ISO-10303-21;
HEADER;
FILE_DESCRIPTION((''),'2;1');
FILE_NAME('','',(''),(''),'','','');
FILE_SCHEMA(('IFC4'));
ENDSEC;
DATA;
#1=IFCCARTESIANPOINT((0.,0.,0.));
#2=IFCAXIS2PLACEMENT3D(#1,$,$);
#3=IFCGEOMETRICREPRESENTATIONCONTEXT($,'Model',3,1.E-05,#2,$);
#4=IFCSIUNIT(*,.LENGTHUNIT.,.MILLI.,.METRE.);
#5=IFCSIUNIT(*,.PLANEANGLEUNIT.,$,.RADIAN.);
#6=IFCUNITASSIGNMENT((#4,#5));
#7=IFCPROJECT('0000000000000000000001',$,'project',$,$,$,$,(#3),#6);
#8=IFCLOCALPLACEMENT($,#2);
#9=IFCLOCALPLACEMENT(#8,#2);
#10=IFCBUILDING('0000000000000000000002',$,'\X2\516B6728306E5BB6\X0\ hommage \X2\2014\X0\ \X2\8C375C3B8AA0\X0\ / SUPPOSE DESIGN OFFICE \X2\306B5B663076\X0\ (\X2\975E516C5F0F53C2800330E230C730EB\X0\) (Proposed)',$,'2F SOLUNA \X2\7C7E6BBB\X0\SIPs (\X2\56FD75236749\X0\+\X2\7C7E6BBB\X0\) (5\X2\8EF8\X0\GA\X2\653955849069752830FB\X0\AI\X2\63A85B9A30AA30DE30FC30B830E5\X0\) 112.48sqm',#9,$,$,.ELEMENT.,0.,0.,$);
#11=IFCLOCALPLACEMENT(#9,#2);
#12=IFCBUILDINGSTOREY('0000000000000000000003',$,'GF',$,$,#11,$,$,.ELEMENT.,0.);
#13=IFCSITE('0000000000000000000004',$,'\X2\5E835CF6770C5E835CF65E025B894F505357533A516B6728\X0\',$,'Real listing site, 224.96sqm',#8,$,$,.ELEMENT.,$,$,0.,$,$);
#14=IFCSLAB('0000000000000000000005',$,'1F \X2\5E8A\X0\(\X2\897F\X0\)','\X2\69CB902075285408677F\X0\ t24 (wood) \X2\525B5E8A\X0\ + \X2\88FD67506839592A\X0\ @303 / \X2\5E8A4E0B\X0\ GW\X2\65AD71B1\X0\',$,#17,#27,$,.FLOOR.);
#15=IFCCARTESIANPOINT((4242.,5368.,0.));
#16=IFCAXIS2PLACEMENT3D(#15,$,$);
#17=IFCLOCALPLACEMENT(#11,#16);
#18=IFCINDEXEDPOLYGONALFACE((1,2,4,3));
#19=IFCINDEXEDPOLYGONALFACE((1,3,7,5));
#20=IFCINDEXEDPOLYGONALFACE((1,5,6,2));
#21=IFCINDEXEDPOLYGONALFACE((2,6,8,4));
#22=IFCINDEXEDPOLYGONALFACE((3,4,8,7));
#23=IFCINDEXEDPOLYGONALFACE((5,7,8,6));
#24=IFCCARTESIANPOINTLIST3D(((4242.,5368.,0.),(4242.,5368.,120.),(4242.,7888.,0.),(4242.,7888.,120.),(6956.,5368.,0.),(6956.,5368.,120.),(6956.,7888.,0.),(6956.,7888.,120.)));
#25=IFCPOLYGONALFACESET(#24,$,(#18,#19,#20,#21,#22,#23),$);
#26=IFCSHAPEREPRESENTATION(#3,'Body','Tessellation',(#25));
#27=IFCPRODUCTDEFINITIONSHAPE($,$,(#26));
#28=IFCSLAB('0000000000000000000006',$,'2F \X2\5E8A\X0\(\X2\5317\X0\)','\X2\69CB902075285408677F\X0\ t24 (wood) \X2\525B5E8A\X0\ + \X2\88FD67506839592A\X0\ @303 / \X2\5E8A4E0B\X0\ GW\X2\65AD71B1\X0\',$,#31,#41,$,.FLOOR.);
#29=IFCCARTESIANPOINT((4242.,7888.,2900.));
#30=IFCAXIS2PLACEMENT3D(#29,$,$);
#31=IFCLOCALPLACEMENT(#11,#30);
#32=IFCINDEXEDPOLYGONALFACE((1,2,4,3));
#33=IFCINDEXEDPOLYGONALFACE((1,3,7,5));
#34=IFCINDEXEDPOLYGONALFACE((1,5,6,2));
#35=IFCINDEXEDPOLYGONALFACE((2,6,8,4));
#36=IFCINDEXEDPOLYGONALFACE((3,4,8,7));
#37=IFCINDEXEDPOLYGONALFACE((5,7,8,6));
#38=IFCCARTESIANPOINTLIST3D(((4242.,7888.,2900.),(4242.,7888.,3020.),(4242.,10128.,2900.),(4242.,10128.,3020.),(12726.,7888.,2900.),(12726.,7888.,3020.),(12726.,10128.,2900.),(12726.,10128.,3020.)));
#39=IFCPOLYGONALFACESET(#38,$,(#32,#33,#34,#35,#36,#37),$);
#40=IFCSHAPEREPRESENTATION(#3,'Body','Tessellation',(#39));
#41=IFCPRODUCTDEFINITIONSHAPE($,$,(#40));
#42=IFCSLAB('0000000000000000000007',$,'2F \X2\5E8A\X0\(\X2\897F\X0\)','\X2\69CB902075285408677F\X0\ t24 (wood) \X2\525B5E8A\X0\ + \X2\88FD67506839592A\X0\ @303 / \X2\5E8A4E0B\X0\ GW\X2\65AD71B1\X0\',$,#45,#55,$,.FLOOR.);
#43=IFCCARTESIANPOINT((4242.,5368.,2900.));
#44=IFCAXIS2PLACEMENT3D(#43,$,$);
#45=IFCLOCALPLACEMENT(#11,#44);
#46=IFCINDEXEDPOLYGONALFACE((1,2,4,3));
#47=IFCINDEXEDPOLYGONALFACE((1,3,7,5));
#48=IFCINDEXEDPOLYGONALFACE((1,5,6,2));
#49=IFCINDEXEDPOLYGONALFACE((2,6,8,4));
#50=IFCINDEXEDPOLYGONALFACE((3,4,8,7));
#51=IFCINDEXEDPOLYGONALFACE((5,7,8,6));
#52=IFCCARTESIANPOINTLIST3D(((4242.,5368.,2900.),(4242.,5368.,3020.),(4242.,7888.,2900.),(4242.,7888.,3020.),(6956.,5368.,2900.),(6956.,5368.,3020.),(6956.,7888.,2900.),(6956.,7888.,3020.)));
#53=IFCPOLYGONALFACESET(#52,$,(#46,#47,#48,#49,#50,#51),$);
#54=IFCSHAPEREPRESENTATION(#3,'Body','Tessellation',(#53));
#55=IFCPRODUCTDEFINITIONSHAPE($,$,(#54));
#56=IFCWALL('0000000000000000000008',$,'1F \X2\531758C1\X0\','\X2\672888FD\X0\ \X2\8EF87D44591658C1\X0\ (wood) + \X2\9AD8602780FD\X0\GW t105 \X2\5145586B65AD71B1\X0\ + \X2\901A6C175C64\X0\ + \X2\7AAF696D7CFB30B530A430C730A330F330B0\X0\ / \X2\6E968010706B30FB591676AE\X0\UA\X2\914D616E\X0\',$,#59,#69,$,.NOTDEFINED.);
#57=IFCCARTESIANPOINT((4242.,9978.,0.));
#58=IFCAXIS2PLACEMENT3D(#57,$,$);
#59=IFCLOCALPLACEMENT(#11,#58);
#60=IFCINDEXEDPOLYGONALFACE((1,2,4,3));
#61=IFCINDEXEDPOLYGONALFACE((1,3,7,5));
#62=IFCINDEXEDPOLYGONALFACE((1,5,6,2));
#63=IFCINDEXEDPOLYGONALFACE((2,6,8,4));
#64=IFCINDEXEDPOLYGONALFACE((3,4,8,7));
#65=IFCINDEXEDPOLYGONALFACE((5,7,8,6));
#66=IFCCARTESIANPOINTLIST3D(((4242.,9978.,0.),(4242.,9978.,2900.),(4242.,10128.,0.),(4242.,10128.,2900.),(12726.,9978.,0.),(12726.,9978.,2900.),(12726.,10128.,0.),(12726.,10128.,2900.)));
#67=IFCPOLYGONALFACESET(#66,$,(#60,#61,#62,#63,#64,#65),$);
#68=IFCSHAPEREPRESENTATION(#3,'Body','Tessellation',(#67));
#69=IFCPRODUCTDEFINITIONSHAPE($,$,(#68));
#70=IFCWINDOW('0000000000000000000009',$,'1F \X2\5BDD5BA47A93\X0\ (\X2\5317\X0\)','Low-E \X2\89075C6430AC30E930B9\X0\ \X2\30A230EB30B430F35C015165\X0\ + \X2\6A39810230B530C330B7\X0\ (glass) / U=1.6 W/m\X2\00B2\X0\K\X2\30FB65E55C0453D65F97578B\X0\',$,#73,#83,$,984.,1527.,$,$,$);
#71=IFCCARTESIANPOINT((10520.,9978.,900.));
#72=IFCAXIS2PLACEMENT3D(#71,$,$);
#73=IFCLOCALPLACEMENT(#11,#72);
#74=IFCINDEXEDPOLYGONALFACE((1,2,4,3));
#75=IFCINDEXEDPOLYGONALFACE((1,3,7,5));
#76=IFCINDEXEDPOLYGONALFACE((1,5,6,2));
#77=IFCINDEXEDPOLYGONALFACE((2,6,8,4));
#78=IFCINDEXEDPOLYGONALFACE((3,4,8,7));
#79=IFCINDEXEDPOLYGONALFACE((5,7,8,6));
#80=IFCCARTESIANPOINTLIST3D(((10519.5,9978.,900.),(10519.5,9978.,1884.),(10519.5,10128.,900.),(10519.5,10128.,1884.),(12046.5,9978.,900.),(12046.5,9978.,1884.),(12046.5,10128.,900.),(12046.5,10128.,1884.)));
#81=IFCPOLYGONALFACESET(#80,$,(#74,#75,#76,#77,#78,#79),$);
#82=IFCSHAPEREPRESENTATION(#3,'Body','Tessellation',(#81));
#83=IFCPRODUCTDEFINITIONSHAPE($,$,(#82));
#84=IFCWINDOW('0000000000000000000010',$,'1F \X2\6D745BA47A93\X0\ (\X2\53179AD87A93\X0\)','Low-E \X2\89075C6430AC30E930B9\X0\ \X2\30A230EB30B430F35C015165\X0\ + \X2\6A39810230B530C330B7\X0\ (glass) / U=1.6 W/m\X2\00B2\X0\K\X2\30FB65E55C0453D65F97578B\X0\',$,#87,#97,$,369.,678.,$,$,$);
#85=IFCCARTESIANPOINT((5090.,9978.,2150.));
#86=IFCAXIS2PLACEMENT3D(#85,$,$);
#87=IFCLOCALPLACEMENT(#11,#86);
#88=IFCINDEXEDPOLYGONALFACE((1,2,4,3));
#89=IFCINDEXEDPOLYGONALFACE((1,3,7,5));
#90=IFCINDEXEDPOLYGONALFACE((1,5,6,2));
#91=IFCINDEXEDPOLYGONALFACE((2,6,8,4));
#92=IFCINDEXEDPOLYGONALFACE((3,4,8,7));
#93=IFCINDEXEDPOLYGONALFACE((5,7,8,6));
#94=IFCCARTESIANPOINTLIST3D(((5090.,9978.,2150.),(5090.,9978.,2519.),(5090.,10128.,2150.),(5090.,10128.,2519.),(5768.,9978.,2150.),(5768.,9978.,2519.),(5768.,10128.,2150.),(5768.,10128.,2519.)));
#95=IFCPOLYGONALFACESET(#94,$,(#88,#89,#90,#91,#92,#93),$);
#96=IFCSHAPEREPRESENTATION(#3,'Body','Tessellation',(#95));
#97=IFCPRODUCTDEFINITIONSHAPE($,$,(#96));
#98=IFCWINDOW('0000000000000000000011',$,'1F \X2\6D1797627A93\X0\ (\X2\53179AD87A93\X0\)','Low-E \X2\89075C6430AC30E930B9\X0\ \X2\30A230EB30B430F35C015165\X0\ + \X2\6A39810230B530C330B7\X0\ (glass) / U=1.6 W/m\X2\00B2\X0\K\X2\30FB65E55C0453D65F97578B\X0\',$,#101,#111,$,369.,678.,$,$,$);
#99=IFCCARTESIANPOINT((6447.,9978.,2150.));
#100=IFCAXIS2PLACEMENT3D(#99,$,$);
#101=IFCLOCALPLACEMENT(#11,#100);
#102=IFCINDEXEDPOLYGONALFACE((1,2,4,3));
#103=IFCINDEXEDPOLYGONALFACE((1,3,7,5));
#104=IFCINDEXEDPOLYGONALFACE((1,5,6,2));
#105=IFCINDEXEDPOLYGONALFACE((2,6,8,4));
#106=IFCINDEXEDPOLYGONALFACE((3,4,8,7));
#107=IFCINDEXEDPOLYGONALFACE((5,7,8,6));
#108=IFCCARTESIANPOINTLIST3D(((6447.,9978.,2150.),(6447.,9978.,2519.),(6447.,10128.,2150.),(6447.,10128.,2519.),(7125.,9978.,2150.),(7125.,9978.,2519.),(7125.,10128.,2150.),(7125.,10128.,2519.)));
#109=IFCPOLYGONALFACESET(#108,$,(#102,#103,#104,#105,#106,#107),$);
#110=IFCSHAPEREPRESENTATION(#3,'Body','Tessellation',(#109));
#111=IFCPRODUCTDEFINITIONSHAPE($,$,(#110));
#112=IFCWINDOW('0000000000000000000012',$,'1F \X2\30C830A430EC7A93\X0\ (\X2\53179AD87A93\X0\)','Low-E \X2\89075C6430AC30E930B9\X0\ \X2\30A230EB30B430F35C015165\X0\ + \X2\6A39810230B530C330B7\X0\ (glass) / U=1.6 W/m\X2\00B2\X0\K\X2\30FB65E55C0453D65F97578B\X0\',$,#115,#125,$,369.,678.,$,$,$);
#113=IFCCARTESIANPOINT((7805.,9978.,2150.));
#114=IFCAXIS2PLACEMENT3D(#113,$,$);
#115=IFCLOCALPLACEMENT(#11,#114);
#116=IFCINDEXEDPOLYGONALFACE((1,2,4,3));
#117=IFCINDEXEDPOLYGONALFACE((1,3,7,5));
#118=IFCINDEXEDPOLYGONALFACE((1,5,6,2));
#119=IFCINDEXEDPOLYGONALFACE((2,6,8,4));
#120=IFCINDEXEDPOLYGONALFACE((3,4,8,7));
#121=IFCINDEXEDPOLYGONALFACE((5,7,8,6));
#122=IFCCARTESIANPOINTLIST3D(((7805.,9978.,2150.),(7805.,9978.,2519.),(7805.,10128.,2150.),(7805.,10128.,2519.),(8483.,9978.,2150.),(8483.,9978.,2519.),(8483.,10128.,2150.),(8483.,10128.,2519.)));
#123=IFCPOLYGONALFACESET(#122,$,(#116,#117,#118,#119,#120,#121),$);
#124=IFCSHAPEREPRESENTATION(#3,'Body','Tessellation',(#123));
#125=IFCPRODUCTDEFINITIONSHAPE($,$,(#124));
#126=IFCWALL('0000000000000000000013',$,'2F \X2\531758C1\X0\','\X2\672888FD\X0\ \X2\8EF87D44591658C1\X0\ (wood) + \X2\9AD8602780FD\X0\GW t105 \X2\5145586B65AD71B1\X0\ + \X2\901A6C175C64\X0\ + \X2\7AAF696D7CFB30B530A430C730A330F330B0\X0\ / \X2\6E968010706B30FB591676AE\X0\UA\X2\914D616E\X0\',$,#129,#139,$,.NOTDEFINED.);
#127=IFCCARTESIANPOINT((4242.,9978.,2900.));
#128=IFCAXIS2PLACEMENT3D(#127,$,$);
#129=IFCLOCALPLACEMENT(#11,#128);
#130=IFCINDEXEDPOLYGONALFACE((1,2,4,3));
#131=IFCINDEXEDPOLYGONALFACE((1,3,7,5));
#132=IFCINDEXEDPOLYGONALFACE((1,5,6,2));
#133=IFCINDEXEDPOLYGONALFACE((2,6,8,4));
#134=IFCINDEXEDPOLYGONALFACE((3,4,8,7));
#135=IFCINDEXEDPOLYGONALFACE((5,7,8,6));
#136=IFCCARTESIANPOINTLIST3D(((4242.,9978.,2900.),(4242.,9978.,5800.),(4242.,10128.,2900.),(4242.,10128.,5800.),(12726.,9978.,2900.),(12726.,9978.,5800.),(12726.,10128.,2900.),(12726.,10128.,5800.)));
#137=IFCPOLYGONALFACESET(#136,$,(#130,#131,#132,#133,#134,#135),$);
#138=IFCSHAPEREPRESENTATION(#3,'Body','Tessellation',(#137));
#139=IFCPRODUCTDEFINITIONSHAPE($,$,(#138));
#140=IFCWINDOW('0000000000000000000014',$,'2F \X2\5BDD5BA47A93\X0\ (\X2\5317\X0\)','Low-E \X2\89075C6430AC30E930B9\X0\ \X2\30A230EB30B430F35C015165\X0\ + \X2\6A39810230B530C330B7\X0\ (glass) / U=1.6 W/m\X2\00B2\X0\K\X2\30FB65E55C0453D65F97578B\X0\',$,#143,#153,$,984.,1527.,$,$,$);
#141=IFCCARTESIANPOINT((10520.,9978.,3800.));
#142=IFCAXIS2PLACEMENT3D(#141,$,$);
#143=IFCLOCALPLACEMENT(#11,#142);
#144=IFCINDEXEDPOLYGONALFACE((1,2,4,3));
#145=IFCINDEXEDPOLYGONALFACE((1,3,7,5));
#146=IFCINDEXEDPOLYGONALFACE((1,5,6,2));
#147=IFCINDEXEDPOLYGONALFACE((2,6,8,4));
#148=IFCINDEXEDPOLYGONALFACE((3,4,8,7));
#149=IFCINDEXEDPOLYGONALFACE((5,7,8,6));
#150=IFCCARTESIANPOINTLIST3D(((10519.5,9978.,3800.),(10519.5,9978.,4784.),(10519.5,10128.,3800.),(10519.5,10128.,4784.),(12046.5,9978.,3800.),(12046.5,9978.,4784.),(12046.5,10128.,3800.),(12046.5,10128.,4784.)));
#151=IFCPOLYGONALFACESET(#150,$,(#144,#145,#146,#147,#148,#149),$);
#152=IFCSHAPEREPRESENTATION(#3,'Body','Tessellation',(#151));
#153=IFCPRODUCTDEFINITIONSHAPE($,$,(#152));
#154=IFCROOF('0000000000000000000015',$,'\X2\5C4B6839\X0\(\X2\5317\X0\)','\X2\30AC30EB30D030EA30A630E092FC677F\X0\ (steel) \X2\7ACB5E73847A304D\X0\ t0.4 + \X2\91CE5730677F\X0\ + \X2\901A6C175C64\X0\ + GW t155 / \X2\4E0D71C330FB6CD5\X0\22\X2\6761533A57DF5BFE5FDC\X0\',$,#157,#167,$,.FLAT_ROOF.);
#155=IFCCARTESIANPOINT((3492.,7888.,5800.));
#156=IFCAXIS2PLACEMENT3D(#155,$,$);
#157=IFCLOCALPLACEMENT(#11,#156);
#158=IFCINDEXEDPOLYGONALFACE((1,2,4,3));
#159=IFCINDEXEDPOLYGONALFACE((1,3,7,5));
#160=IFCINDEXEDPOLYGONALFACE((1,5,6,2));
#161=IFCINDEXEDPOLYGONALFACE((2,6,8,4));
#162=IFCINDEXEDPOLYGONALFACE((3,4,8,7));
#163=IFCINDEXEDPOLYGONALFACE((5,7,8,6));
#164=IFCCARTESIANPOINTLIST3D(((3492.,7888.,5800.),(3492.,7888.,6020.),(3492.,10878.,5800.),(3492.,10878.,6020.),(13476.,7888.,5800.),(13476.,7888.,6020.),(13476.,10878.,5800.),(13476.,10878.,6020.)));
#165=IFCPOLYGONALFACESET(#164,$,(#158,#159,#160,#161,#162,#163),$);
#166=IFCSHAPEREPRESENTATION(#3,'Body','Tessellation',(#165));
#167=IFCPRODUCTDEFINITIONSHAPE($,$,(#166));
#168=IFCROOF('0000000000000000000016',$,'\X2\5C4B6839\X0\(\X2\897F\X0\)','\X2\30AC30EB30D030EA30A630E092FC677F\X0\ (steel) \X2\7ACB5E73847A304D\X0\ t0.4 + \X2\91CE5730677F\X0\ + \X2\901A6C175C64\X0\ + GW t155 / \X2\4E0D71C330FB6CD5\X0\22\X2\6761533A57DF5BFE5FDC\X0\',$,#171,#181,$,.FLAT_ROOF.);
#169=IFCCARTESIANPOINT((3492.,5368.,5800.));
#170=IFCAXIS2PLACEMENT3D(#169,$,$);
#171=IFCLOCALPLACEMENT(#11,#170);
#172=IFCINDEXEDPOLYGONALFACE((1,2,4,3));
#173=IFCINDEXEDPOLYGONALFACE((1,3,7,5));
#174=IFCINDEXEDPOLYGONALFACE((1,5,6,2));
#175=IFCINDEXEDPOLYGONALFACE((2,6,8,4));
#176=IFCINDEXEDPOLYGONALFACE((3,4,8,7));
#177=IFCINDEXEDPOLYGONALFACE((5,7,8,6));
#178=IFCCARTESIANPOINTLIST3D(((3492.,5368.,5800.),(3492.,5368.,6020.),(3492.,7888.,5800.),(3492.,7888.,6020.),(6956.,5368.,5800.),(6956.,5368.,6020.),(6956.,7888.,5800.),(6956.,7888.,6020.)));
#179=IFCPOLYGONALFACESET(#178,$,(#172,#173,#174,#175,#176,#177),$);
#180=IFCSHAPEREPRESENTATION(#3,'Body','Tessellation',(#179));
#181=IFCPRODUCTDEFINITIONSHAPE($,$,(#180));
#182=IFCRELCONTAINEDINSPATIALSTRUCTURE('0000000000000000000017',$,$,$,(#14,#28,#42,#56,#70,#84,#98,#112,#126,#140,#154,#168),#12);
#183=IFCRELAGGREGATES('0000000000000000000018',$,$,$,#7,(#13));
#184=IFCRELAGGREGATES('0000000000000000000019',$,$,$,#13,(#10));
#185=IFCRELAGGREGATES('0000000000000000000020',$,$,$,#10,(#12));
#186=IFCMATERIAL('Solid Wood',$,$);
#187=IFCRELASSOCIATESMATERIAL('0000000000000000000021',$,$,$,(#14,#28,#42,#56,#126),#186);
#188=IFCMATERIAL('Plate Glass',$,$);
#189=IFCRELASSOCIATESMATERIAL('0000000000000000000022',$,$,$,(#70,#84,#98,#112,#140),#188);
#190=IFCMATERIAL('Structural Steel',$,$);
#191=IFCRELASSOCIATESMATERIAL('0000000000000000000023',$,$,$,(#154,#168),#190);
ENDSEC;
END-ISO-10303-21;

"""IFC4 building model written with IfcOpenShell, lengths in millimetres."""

from ifc_helpers import new_model, si_unit, frame, frame_2d, origin, place, context, project, spatial, rectangle, extrude, material, element, fill, save


model = new_model("IFC4")

# Units and contexts
model_context = context("Model", 3, precision=1e-05, world=origin())
ifc_project = project(units=[si_unit("LENGTHUNIT", "METRE", prefix="MILLI"), si_unit("PLANEANGLEUNIT", "RADIAN")], contexts=[model_context])

# Site, building, storey
site_placement = place(None, origin())
site = spatial("IfcSite", under=ifc_project, at=site_placement, Name="広島県広島市安佐南区八木", ObjectType="Real listing site, 224.96sqm", CompositionType="ELEMENT", RefElevation=0.0)
building_placement = place(site_placement, origin())
building = spatial("IfcBuilding", under=site, at=building_placement, Name="八木の家 hommage — 谷尻誠 / SUPPOSE DESIGN OFFICE に学ぶ (非公式参考モデル) (Proposed)", ObjectType="2F SOLUNA 籾殻SIPs (国産杉+籾殻) (5軸GA改善適用・AI推定オマージュ) 112.48sqm", CompositionType="ELEMENT", ElevationOfRefHeight=0.0, ElevationOfTerrain=0.0)
storey_placement = place(building_placement, origin())
storey = spatial("IfcBuildingStorey", under=building, at=storey_placement, Name="GF", CompositionType="ELEMENT", Elevation=0.0)

# Slabs
ifc_material_1 = material(Name="Solid Wood")
slab_1_placement = place(storey_placement, frame((4242.0, 5368.0, 0.0)))
element("IfcSlab", 1, at=slab_1_placement, inside=storey, material=ifc_material_1, Name="1F 床(西)", Description="構造用合板 t24 (wood) 剛床 + 製材根太 @303 / 床下 GW断熱", PredefinedType="FLOOR", context=model_context, shape_type="SweptSolid", body=[
    extrude(rectangle(XDim=2714.0, YDim=2520.0, at=frame_2d((1357.0, 1260.0))), frame((4242.0, 5368.0, 0.0)), (0.0, 0.0, 1.0), 120.0),
])
slab_2_placement = place(storey_placement, frame((4242.0, 7888.0, 2900.0)))
element("IfcSlab", 2, at=slab_2_placement, inside=storey, material=ifc_material_1, Name="2F 床(北)", Description="構造用合板 t24 (wood) 剛床 + 製材根太 @303 / 床下 GW断熱", PredefinedType="FLOOR", context=model_context, shape_type="SweptSolid", body=[
    extrude(rectangle(XDim=8484.0, YDim=2240.0, at=frame_2d((4242.0, 1120.0))), frame((4242.0, 7888.0, 2900.0)), (0.0, 0.0, 1.0), 120.0),
])
slab_3_placement = place(storey_placement, frame((4242.0, 5368.0, 2900.0)))
element("IfcSlab", 3, at=slab_3_placement, inside=storey, material=ifc_material_1, Name="2F 床(西)", Description="構造用合板 t24 (wood) 剛床 + 製材根太 @303 / 床下 GW断熱", PredefinedType="FLOOR", context=model_context, shape_type="SweptSolid", body=[
    extrude(rectangle(XDim=2714.0, YDim=2520.0, at=frame_2d((1357.0, 1260.0))), frame((4242.0, 5368.0, 2900.0)), (0.0, 0.0, 1.0), 120.0),
])

# Wall, openings, windows
wall_1_placement = place(storey_placement, frame((4242.0, 9978.0, 0.0)))
wall_1 = element("IfcWall", 4, at=wall_1_placement, inside=storey, material=ifc_material_1, Name="1F 北壁", Description="木製 軸組外壁 (wood) + 高性能GW t105 充填断熱 + 通気層 + 窯業系サイディング / 準耐火・外皮UA配慮", PredefinedType="NOTDEFINED", context=model_context, shape_type="SweptSolid", body=[
    extrude(rectangle(XDim=8484.0, YDim=150.0, at=frame_2d((4242.0, 75.0))), frame((4242.0, 9978.0, 0.0)), (0.0, 0.0, 1.0), 2900.0),
])
opening_1_placement = place(storey_placement, frame((10520.0, 9978.0, 900.0)))
opening_1 = element("IfcOpeningElement", 5, at=opening_1_placement, cuts=wall_1, PredefinedType="NOTDEFINED", context=model_context, shape_type="SweptSolid", body=[
    extrude(rectangle(XDim=1527.0, YDim=150.0, at=frame_2d((763.0, 75.0))), frame((10520.0, 9978.0, 900.0)), (0.0, 0.0, 1.0), 984.0),
])
opening_2_placement = place(storey_placement, frame((5090.0, 9978.0, 2150.0)))
opening_2 = element("IfcOpeningElement", 6, at=opening_2_placement, cuts=wall_1, PredefinedType="NOTDEFINED", context=model_context, shape_type="SweptSolid", body=[
    extrude(rectangle(XDim=678.0, YDim=150.0, at=frame_2d((339.0, 75.0))), frame((5090.0, 9978.0, 2150.0)), (0.0, 0.0, 1.0), 369.0),
])
opening_3_placement = place(storey_placement, frame((6447.0, 9978.0, 2150.0)))
opening_3 = element("IfcOpeningElement", 7, at=opening_3_placement, cuts=wall_1, PredefinedType="NOTDEFINED", context=model_context, shape_type="SweptSolid", body=[
    extrude(rectangle(XDim=678.0, YDim=150.0, at=frame_2d((339.0, 75.0))), frame((6447.0, 9978.0, 2150.0)), (0.0, 0.0, 1.0), 369.0),
])
opening_4_placement = place(storey_placement, frame((7805.0, 9978.0, 2150.0)))
opening_4 = element("IfcOpeningElement", 8, at=opening_4_placement, cuts=wall_1, PredefinedType="NOTDEFINED", context=model_context, shape_type="SweptSolid", body=[
    extrude(rectangle(XDim=678.0, YDim=150.0, at=frame_2d((339.0, 75.0))), frame((7805.0, 9978.0, 2150.0)), (0.0, 0.0, 1.0), 369.0),
])
ifc_material_2 = material(Name="Plate Glass")
window_1_placement = place(storey_placement, frame((10520.0, 9978.0, 900.0)))
window_1 = element("IfcWindow", 9, at=window_1_placement, inside=storey, material=ifc_material_2, Name="1F 寝室窓 (北)", Description="Low-E 複層ガラス アルゴン封入 + 樹脂サッシ (glass) / U=1.6 W/m²K・日射取得型", OverallHeight=984.0, OverallWidth=1527.0, context=model_context, shape_type="SweptSolid", body=[
    extrude(rectangle(XDim=1527.0, YDim=150.0, at=frame_2d((763.0, 75.0))), frame((10520.0, 9978.0, 900.0)), (0.0, 0.0, 1.0), 984.0),
])
fill(opening_1, window_1)
window_2_placement = place(storey_placement, frame((5090.0, 9978.0, 2150.0)))
window_2 = element("IfcWindow", 10, at=window_2_placement, inside=storey, material=ifc_material_2, Name="1F 浴室窓 (北高窓)", Description="Low-E 複層ガラス アルゴン封入 + 樹脂サッシ (glass) / U=1.6 W/m²K・日射取得型", OverallHeight=369.0, OverallWidth=678.0, context=model_context, shape_type="SweptSolid", body=[
    extrude(rectangle(XDim=678.0, YDim=150.0, at=frame_2d((339.0, 75.0))), frame((5090.0, 9978.0, 2150.0)), (0.0, 0.0, 1.0), 369.0),
])
fill(opening_2, window_2)
window_3_placement = place(storey_placement, frame((6447.0, 9978.0, 2150.0)))
window_3 = element("IfcWindow", 11, at=window_3_placement, inside=storey, material=ifc_material_2, Name="1F 洗面窓 (北高窓)", Description="Low-E 複層ガラス アルゴン封入 + 樹脂サッシ (glass) / U=1.6 W/m²K・日射取得型", OverallHeight=369.0, OverallWidth=678.0, context=model_context, shape_type="SweptSolid", body=[
    extrude(rectangle(XDim=678.0, YDim=150.0, at=frame_2d((339.0, 75.0))), frame((6447.0, 9978.0, 2150.0)), (0.0, 0.0, 1.0), 369.0),
])
fill(opening_3, window_3)
window_4_placement = place(storey_placement, frame((7805.0, 9978.0, 2150.0)))
window_4 = element("IfcWindow", 12, at=window_4_placement, inside=storey, material=ifc_material_2, Name="1F トイレ窓 (北高窓)", Description="Low-E 複層ガラス アルゴン封入 + 樹脂サッシ (glass) / U=1.6 W/m²K・日射取得型", OverallHeight=369.0, OverallWidth=678.0, context=model_context, shape_type="SweptSolid", body=[
    extrude(rectangle(XDim=678.0, YDim=150.0, at=frame_2d((339.0, 75.0))), frame((7805.0, 9978.0, 2150.0)), (0.0, 0.0, 1.0), 369.0),
])
fill(opening_4, window_4)

# Wall, opening, window
wall_2_placement = place(storey_placement, frame((4242.0, 9978.0, 2900.0)))
wall_2 = element("IfcWall", 13, at=wall_2_placement, inside=storey, material=ifc_material_1, Name="2F 北壁", Description="木製 軸組外壁 (wood) + 高性能GW t105 充填断熱 + 通気層 + 窯業系サイディング / 準耐火・外皮UA配慮", PredefinedType="NOTDEFINED", context=model_context, shape_type="SweptSolid", body=[
    extrude(rectangle(XDim=8484.0, YDim=150.0, at=frame_2d((4242.0, 75.0))), frame((4242.0, 9978.0, 2900.0)), (0.0, 0.0, 1.0), 2900.0),
])
opening_5_placement = place(storey_placement, frame((10520.0, 9978.0, 3800.0)))
opening_5 = element("IfcOpeningElement", 14, at=opening_5_placement, cuts=wall_2, PredefinedType="NOTDEFINED", context=model_context, shape_type="SweptSolid", body=[
    extrude(rectangle(XDim=1527.0, YDim=150.0, at=frame_2d((763.0, 75.0))), frame((10520.0, 9978.0, 3800.0)), (0.0, 0.0, 1.0), 984.0),
])
window_5_placement = place(storey_placement, frame((10520.0, 9978.0, 3800.0)))
window_5 = element("IfcWindow", 15, at=window_5_placement, inside=storey, material=ifc_material_2, Name="2F 寝室窓 (北)", Description="Low-E 複層ガラス アルゴン封入 + 樹脂サッシ (glass) / U=1.6 W/m²K・日射取得型", OverallHeight=984.0, OverallWidth=1527.0, context=model_context, shape_type="SweptSolid", body=[
    extrude(rectangle(XDim=1527.0, YDim=150.0, at=frame_2d((763.0, 75.0))), frame((10520.0, 9978.0, 3800.0)), (0.0, 0.0, 1.0), 984.0),
])
fill(opening_5, window_5)

# Roofs
ifc_material_3 = material(Name="Structural Steel")
for number, where, name in (
    (16, (3492.0, 7888.0, 5800.0), "屋根(北)"),
):
    element("IfcRoof", number, at=place(storey_placement, frame(where)), inside=storey, material=ifc_material_3, Name=name, Description="ガルバリウム鋼板 (steel) 立平葺き t0.4 + 野地板 + 通気層 + GW t155 / 不燃・法22条区域対応", PredefinedType="FLAT_ROOF", context=model_context, shape_type="SweptSolid", body=[
        extrude(rectangle(XDim=9984.0, YDim=2990.0, at=frame_2d((4992.0, 1495.0))), frame((3492.0, 7888.0, 5800.0)), (0.0, 0.0, 1.0), 220.0),
    ])
roof_placement = place(storey_placement, frame((3492.0, 5368.0, 5800.0)))
element("IfcRoof", 17, at=roof_placement, inside=storey, material=ifc_material_3, Name="屋根(西)", Description="ガルバリウム鋼板 (steel) 立平葺き t0.4 + 野地板 + 通気層 + GW t155 / 不燃・法22条区域対応", PredefinedType="FLAT_ROOF", context=model_context, shape_type="SweptSolid", body=[
    extrude(rectangle(XDim=3464.0, YDim=2520.0, at=frame_2d((1732.0, 1260.0))), frame((3492.0, 5368.0, 5800.0)), (0.0, 0.0, 1.0), 220.0),
])

save(model, "model.ifc")
